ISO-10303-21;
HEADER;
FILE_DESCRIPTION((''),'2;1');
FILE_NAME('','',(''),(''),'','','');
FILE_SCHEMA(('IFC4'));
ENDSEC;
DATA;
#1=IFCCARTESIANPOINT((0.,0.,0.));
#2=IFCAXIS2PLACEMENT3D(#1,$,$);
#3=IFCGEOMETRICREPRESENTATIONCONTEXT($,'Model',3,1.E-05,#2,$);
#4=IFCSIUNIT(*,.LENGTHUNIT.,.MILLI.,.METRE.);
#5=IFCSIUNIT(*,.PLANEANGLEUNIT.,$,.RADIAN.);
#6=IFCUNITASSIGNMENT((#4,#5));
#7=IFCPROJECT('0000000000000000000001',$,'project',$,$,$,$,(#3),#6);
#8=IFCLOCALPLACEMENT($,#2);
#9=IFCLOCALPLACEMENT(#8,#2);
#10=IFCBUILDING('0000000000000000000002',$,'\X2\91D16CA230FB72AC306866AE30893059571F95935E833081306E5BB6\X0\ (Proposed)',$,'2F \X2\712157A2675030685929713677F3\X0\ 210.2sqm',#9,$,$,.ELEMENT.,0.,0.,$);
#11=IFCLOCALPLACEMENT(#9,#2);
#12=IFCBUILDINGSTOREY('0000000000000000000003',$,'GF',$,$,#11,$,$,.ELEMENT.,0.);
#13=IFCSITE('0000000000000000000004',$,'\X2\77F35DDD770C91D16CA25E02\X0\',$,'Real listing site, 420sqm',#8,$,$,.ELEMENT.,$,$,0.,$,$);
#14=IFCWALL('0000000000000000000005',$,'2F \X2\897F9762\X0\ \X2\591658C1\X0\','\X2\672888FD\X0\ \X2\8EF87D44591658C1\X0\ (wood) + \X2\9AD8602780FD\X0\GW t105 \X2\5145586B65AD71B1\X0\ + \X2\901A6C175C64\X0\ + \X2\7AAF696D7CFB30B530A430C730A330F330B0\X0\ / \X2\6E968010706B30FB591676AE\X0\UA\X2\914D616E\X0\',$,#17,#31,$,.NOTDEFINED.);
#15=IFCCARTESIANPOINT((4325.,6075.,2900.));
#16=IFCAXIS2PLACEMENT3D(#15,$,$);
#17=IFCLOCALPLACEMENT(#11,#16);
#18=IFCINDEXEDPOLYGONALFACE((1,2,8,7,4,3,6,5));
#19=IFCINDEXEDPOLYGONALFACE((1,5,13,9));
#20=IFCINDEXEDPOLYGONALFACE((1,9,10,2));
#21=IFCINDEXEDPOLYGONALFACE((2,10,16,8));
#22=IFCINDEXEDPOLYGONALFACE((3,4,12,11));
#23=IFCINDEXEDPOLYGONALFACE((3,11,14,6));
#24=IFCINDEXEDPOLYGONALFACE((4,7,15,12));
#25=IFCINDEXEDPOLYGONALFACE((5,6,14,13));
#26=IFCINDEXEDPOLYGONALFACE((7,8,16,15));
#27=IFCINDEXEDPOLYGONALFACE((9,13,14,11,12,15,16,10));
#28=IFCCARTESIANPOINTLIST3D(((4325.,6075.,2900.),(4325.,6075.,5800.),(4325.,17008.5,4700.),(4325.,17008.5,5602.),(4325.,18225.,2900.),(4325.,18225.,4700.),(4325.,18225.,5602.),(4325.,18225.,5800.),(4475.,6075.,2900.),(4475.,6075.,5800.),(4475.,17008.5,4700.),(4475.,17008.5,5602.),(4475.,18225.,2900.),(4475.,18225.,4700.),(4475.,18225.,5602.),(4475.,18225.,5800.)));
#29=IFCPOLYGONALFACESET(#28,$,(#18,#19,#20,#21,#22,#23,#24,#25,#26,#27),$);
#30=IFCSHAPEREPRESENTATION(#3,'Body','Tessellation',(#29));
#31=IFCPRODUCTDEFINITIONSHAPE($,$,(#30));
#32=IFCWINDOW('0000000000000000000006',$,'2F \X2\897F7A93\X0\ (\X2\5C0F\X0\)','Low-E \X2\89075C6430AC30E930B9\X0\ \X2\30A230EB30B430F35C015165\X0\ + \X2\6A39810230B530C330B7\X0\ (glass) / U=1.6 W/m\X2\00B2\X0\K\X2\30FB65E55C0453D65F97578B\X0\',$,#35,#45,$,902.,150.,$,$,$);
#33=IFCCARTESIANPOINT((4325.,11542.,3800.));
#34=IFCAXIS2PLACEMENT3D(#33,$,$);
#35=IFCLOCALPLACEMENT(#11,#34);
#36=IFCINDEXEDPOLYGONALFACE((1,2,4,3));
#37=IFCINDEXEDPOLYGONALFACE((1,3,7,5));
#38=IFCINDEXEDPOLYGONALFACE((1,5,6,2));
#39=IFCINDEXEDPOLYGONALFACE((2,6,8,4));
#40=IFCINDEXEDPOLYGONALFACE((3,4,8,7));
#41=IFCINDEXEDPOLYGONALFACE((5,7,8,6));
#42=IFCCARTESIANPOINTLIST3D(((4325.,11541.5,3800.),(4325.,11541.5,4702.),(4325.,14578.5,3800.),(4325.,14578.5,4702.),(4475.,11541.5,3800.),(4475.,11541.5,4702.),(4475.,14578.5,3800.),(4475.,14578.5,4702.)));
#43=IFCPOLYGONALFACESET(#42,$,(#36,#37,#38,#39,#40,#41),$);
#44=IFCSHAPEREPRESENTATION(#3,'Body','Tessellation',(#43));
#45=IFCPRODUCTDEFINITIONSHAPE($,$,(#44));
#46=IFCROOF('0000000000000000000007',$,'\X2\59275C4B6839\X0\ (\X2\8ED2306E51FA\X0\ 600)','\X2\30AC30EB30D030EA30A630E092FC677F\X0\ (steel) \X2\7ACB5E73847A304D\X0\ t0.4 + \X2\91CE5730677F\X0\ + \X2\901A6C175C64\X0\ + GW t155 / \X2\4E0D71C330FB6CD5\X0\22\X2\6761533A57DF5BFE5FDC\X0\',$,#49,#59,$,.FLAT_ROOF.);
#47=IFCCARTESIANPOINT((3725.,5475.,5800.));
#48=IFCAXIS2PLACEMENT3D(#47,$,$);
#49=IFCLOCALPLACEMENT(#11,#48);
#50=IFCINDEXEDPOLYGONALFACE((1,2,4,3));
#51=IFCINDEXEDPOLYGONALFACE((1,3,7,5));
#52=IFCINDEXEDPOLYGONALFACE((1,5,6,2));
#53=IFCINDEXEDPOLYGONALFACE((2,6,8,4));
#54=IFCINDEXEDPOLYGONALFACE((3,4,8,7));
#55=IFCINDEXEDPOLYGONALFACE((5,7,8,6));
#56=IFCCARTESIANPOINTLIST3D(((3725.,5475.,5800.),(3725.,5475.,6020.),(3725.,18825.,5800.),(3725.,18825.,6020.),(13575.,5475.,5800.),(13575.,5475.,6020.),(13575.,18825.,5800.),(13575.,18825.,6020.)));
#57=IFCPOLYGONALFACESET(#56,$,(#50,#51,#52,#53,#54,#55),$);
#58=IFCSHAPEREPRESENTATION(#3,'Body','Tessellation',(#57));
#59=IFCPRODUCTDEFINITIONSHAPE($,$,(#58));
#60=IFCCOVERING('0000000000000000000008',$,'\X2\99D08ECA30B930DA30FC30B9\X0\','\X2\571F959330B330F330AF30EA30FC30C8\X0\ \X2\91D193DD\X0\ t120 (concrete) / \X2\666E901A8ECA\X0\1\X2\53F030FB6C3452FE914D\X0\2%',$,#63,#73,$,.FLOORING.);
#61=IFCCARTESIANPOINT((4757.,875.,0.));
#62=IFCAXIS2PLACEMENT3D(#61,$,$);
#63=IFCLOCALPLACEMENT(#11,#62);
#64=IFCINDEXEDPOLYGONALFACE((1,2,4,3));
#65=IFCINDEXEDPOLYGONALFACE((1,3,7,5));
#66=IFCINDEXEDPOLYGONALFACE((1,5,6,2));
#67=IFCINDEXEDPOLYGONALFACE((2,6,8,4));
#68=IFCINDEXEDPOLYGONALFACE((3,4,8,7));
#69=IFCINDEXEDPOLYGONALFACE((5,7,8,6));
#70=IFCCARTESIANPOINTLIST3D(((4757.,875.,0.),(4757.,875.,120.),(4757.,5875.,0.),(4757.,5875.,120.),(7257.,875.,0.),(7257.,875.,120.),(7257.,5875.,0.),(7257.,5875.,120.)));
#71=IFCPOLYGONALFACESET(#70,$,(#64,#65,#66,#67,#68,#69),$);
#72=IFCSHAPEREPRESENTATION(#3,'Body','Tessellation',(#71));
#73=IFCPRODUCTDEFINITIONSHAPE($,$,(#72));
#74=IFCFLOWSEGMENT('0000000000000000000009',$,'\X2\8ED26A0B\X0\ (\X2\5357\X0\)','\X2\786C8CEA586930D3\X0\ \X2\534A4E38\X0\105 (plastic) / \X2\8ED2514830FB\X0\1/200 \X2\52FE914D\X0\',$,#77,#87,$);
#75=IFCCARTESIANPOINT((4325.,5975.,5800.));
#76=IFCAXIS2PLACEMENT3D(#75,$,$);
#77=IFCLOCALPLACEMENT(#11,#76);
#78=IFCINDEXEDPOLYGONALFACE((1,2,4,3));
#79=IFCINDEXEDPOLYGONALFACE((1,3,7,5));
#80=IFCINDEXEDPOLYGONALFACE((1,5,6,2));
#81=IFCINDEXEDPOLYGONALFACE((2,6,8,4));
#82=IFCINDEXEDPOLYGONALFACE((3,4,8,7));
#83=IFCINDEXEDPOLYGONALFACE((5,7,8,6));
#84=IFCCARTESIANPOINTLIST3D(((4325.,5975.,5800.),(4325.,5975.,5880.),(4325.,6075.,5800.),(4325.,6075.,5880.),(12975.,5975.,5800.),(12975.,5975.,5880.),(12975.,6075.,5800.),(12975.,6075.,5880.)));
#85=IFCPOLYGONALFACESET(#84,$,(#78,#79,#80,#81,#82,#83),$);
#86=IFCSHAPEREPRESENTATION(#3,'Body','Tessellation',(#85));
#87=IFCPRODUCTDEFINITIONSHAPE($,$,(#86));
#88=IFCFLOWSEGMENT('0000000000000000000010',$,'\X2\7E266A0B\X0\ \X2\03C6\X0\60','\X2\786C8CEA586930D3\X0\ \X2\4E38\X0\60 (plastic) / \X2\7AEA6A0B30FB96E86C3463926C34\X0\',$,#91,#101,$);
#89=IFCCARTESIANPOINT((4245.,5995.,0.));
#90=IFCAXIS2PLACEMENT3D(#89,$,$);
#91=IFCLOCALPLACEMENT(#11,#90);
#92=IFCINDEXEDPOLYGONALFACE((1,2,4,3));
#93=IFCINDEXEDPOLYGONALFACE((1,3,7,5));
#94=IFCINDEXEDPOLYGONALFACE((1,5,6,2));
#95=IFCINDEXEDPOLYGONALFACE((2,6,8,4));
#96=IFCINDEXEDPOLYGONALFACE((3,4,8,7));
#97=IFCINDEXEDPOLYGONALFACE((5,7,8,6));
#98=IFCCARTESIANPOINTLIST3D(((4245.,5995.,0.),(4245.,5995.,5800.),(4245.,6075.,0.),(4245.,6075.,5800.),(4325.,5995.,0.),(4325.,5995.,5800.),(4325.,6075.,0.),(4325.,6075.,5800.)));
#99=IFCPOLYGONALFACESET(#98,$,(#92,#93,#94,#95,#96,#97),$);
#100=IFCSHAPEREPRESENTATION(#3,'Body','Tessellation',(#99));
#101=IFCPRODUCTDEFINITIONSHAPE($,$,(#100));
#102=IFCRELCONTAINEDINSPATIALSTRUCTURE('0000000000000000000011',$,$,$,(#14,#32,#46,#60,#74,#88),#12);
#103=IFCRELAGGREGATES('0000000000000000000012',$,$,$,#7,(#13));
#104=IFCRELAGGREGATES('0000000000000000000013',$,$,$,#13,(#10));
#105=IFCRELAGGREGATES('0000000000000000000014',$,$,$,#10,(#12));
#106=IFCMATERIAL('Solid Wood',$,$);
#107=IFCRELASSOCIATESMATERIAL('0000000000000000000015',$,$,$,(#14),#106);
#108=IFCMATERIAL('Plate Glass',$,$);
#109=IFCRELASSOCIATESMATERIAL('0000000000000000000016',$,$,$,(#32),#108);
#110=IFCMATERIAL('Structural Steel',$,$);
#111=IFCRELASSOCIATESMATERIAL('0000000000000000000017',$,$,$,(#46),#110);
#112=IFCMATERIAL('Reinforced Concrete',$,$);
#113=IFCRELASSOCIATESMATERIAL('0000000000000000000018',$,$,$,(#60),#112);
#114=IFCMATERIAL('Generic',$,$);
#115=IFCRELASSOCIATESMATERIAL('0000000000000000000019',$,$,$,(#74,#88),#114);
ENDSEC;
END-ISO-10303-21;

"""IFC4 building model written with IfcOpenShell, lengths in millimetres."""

from ifc_helpers import new_model, si_unit, frame, frame_2d, origin, place, context, project, spatial, rectangle, extrude, material, element, fill, save


model = new_model("IFC4")

# Units and contexts
model_context = context("Model", 3, precision=1e-05, world=origin())
ifc_project = project(units=[si_unit("LENGTHUNIT", "METRE", prefix="MILLI"), si_unit("PLANEANGLEUNIT", "RADIAN")], contexts=[model_context])

# Site, building, storey
site_placement = place(None, origin())
site = spatial("IfcSite", under=ifc_project, at=site_placement, Name="石川県金沢市", ObjectType="Real listing site, 420sqm", CompositionType="ELEMENT", RefElevation=0.0)
building_placement = place(site_placement, origin())
building = spatial("IfcBuilding", under=site, at=building_placement, Name="金沢・犬と暮らす土間広めの家 (Proposed)", ObjectType="2F 無垢材と天然石 210.2sqm", CompositionType="ELEMENT", ElevationOfRefHeight=0.0, ElevationOfTerrain=0.0)
storey_placement = place(building_placement, origin())
storey = spatial("IfcBuildingStorey", under=building, at=storey_placement, Name="GF", CompositionType="ELEMENT", Elevation=0.0)

# Shared definitions
ifc_material_1 = material(Name="Solid Wood")

# Shared definitions
ifc_material_2 = material(Name="Reinforced Concrete")

# Shared definitions
ifc_material_3 = material(Name="Plate Glass")

# Wall, opening, window
wall_1_placement = place(storey_placement, frame((4325.0, 6075.0, 2900.0)))
wall_1 = element("IfcWall", 1, at=wall_1_placement, inside=storey, material=ifc_material_1, Name="2F 西面 外壁", Description="木製 軸組外壁 (wood) + 高性能GW t105 充填断熱 + 通気層 + 窯業系サイディング / 準耐火・外皮UA配慮", PredefinedType="NOTDEFINED", context=model_context, shape_type="SweptSolid", body=[
    extrude(rectangle(XDim=150.0, YDim=12150.0, at=frame_2d((75.0, 6075.0))), frame((4325.0, 6075.0, 2900.0)), (0.0, 0.0, 1.0), 2900.0),
])
opening_1_placement = place(storey_placement, frame((4325.0, 11542.0, 3800.0)))
opening_1 = element("IfcOpeningElement", 2, at=opening_1_placement, cuts=wall_1, PredefinedType="NOTDEFINED", context=model_context, shape_type="SweptSolid", body=[
    extrude(rectangle(XDim=150.0, YDim=3037.0, at=frame_2d((75.0, 1518.0))), frame((4325.0, 11542.0, 3800.0)), (0.0, 0.0, 1.0), 902.0),
])
window_1_placement = place(storey_placement, frame((4325.0, 11542.0, 3800.0)))
window_1 = element("IfcWindow", 3, at=window_1_placement, inside=storey, material=ifc_material_3, Name="2F 西窓 (小)", Description="Low-E 複層ガラス アルゴン封入 + 樹脂サッシ (glass) / U=1.6 W/m²K・日射取得型", OverallHeight=902.0, OverallWidth=150.0, context=model_context, shape_type="SweptSolid", body=[
    extrude(rectangle(XDim=150.0, YDim=3037.0, at=frame_2d((75.0, 1518.0))), frame((4325.0, 11542.0, 3800.0)), (0.0, 0.0, 1.0), 902.0),
])
fill(opening_1, window_1)

# Roof
ifc_material_4 = material(Name="Structural Steel")
roof_placement = place(storey_placement, frame((3725.0, 5475.0, 5800.0)))
element("IfcRoof", 4, at=roof_placement, inside=storey, material=ifc_material_4, Name="大屋根 (軒の出 600)", Description="ガルバリウム鋼板 (steel) 立平葺き t0.4 + 野地板 + 通気層 + GW t155 / 不燃・法22条区域対応", PredefinedType="FLAT_ROOF", context=model_context, shape_type="SweptSolid", body=[
    extrude(rectangle(XDim=9850.0, YDim=13350.0, at=frame_2d((4925.0, 6675.0))), frame((3725.0, 5475.0, 5800.0)), (0.0, 0.0, 1.0), 220.0),
])

# Covering
covering_placement = place(storey_placement, frame((4757.0, 875.0, 0.0)))
element("IfcCovering", 5, at=covering_placement, inside=storey, material=ifc_material_2, Name="駐車スペース", Description="土間コンクリート 金鏝 t120 (concrete) / 普通車1台・水勾配2%", PredefinedType="FLOORING", context=model_context, shape_type="SweptSolid", body=[
    extrude(rectangle(XDim=2500.0, YDim=5000.0, at=frame_2d((1250.0, 2500.0))), frame((4757.0, 875.0, 0.0)), (0.0, 0.0, 1.0), 120.0),
])

# Flow segments
ifc_material_5 = material(Name="Generic")
flow_segment_1_placement = place(storey_placement, frame((4325.0, 5975.0, 5800.0)))
element("IfcFlowSegment", 6, at=flow_segment_1_placement, inside=storey, material=ifc_material_5, Name="軒樋 (南)", Description="硬質塩ビ 半丸105 (plastic) / 軒先・1/200 勾配", context=model_context, shape_type="SweptSolid", body=[
    extrude(rectangle(XDim=8650.0, YDim=100.0, at=frame_2d((4325.0, 50.0))), frame((4325.0, 5975.0, 5800.0)), (0.0, 0.0, 1.0), 80.0),
])
flow_segment_2_placement = place(storey_placement, frame((4245.0, 5995.0, 0.0)))
element("IfcFlowSegment", 7, at=flow_segment_2_placement, inside=storey, material=ifc_material_5, Name="縦樋 φ60", Description="硬質塩ビ 丸60 (plastic) / 竪樋・雨水排水", context=model_context, shape_type="SweptSolid", body=[
    extrude(rectangle(XDim=80.0, YDim=80.0, at=frame_2d((40.0, 40.0))), frame((4245.0, 5995.0, 0.0)), (0.0, 0.0, 1.0), 5800.0),
])

save(model, "model.ifc")
